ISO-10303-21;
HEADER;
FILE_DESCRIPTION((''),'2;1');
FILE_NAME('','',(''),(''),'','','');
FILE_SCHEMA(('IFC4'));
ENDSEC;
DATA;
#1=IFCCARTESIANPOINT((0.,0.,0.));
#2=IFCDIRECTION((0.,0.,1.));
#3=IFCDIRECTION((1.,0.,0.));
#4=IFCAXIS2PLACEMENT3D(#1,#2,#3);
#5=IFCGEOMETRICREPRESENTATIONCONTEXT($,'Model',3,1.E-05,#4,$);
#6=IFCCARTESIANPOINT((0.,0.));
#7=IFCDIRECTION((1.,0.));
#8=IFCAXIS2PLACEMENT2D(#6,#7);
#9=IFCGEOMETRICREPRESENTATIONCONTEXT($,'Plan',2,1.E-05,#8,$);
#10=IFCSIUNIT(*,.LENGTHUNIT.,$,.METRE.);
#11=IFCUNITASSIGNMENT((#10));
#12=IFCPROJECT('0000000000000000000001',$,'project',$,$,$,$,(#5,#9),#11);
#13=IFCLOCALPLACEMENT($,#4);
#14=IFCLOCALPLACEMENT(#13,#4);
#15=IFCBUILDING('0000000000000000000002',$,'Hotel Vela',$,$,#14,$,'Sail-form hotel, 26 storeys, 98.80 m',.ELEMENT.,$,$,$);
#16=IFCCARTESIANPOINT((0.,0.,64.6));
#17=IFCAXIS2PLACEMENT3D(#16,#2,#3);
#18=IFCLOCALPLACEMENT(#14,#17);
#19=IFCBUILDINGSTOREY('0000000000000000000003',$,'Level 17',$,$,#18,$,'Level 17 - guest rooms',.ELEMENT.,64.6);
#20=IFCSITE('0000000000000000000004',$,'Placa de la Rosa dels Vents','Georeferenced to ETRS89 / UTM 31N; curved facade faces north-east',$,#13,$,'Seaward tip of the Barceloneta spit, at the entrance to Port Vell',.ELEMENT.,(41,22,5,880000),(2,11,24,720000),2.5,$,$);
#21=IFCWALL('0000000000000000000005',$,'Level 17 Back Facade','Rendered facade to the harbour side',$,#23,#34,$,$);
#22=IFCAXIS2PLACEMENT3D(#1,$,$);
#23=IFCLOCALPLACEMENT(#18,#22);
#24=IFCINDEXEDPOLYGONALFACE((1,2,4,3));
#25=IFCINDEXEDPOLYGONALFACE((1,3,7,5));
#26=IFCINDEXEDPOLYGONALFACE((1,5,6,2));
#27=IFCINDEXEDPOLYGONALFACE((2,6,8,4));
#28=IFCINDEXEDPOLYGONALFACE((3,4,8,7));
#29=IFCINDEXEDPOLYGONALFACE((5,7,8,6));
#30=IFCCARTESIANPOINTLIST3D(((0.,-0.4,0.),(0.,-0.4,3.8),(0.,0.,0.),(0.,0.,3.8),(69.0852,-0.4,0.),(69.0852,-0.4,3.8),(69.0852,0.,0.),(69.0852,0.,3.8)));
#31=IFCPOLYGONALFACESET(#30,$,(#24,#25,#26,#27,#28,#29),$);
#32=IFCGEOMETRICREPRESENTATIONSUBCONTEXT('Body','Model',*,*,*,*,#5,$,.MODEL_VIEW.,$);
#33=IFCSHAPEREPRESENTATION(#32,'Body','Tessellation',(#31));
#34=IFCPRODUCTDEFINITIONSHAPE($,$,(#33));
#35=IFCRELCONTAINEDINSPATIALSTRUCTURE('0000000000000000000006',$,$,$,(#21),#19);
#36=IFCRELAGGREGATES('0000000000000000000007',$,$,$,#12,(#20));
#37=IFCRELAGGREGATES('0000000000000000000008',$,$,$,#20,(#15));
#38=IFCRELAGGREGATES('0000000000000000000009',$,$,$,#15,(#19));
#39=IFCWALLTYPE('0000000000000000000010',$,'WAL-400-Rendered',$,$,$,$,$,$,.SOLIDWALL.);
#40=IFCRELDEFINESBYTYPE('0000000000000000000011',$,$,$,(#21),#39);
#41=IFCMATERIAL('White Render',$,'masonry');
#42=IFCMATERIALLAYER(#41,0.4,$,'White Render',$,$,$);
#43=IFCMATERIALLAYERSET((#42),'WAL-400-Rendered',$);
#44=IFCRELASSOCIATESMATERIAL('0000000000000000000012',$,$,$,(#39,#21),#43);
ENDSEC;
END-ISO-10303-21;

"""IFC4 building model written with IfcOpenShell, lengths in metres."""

from ifc_helpers import new_model, si_unit, frame, origin_with_axes, origin_2d_with_axis, place, context, subcontext, project, spatial, line, indexed_curve, outline, extrude, material, layer, layer_set, layer_usage, type_object, element, save


model = new_model("IFC4")

# Units and contexts
model_context = context("Model", 3, precision=1e-05, world=origin_with_axes())
plan_context = context("Plan", 2, precision=1e-05, world=origin_2d_with_axis())
body_context = subcontext(model_context, "Body", "Model", "MODEL_VIEW")
ifc_project = project(units=[si_unit("LENGTHUNIT", "METRE")], contexts=[model_context, plan_context])

# Site, building, storey
site_placement = place(None, origin_with_axes())
site = spatial("IfcSite", under=ifc_project, at=site_placement, Name="Placa de la Rosa dels Vents", Description="Georeferenced to ETRS89 / UTM 31N; curved facade faces north-east", LongName="Seaward tip of the Barceloneta spit, at the entrance to Port Vell", CompositionType="ELEMENT", RefLatitude=(41, 22, 5, 880000), RefLongitude=(2, 11, 24, 720000), RefElevation=2.5)
building_placement = place(site_placement, origin_with_axes())
building = spatial("IfcBuilding", under=site, at=building_placement, Name="Hotel Vela", LongName="Sail-form hotel, 26 storeys, 98.80 m", CompositionType="ELEMENT")
storey_placement = place(building_placement, frame((0.0, 0.0, 64.6), z_axis=(0.0, 0.0, 1.0), x_axis=(1.0, 0.0, 0.0)))
storey = spatial("IfcBuildingStorey", under=building, at=storey_placement, Name="Level 17", LongName="Level 17 - guest rooms", CompositionType="ELEMENT", Elevation=64.6)

# Wall
ifc_material_1 = material(Name="White Render", Category="masonry")
ifc_layer_1 = layer(ifc_material_1, 0.4, Name="White Render")
ifc_layer_set_1 = layer_set([ifc_layer_1], Name="WAL-400-Rendered")
ifc_layer_usage_1 = layer_usage(ifc_layer_set_1, "AXIS2", "POSITIVE", 0.0)
wall_type = type_object("IfcWallType", Name="WAL-400-Rendered", PredefinedType="SOLIDWALL", material=ifc_layer_set_1)
wall_placement = place(storey_placement, frame((0.0, -0.4, 0.0), z_axis=(0.0, 0.0, 1.0), x_axis=(1.0, 0.0, 0.0)))
element("IfcWall", 1, at=wall_placement, inside=storey, type_object=wall_type, material=ifc_layer_usage_1, Name="Level 17 Back Facade", Description="Rendered facade to the harbour side", context=body_context, shape_type="SweptSolid", body=[
    extrude(outline(indexed_curve([(0.0, 0.0), (69.0852, 0.0), (69.0852, 0.4), (0.0, 0.4)], segments=[line(1, 2, 3, 4, 1)])), origin_with_axes(), (0.0, 0.0, 1.0), 3.8),
])

save(model, "model.ifc")
